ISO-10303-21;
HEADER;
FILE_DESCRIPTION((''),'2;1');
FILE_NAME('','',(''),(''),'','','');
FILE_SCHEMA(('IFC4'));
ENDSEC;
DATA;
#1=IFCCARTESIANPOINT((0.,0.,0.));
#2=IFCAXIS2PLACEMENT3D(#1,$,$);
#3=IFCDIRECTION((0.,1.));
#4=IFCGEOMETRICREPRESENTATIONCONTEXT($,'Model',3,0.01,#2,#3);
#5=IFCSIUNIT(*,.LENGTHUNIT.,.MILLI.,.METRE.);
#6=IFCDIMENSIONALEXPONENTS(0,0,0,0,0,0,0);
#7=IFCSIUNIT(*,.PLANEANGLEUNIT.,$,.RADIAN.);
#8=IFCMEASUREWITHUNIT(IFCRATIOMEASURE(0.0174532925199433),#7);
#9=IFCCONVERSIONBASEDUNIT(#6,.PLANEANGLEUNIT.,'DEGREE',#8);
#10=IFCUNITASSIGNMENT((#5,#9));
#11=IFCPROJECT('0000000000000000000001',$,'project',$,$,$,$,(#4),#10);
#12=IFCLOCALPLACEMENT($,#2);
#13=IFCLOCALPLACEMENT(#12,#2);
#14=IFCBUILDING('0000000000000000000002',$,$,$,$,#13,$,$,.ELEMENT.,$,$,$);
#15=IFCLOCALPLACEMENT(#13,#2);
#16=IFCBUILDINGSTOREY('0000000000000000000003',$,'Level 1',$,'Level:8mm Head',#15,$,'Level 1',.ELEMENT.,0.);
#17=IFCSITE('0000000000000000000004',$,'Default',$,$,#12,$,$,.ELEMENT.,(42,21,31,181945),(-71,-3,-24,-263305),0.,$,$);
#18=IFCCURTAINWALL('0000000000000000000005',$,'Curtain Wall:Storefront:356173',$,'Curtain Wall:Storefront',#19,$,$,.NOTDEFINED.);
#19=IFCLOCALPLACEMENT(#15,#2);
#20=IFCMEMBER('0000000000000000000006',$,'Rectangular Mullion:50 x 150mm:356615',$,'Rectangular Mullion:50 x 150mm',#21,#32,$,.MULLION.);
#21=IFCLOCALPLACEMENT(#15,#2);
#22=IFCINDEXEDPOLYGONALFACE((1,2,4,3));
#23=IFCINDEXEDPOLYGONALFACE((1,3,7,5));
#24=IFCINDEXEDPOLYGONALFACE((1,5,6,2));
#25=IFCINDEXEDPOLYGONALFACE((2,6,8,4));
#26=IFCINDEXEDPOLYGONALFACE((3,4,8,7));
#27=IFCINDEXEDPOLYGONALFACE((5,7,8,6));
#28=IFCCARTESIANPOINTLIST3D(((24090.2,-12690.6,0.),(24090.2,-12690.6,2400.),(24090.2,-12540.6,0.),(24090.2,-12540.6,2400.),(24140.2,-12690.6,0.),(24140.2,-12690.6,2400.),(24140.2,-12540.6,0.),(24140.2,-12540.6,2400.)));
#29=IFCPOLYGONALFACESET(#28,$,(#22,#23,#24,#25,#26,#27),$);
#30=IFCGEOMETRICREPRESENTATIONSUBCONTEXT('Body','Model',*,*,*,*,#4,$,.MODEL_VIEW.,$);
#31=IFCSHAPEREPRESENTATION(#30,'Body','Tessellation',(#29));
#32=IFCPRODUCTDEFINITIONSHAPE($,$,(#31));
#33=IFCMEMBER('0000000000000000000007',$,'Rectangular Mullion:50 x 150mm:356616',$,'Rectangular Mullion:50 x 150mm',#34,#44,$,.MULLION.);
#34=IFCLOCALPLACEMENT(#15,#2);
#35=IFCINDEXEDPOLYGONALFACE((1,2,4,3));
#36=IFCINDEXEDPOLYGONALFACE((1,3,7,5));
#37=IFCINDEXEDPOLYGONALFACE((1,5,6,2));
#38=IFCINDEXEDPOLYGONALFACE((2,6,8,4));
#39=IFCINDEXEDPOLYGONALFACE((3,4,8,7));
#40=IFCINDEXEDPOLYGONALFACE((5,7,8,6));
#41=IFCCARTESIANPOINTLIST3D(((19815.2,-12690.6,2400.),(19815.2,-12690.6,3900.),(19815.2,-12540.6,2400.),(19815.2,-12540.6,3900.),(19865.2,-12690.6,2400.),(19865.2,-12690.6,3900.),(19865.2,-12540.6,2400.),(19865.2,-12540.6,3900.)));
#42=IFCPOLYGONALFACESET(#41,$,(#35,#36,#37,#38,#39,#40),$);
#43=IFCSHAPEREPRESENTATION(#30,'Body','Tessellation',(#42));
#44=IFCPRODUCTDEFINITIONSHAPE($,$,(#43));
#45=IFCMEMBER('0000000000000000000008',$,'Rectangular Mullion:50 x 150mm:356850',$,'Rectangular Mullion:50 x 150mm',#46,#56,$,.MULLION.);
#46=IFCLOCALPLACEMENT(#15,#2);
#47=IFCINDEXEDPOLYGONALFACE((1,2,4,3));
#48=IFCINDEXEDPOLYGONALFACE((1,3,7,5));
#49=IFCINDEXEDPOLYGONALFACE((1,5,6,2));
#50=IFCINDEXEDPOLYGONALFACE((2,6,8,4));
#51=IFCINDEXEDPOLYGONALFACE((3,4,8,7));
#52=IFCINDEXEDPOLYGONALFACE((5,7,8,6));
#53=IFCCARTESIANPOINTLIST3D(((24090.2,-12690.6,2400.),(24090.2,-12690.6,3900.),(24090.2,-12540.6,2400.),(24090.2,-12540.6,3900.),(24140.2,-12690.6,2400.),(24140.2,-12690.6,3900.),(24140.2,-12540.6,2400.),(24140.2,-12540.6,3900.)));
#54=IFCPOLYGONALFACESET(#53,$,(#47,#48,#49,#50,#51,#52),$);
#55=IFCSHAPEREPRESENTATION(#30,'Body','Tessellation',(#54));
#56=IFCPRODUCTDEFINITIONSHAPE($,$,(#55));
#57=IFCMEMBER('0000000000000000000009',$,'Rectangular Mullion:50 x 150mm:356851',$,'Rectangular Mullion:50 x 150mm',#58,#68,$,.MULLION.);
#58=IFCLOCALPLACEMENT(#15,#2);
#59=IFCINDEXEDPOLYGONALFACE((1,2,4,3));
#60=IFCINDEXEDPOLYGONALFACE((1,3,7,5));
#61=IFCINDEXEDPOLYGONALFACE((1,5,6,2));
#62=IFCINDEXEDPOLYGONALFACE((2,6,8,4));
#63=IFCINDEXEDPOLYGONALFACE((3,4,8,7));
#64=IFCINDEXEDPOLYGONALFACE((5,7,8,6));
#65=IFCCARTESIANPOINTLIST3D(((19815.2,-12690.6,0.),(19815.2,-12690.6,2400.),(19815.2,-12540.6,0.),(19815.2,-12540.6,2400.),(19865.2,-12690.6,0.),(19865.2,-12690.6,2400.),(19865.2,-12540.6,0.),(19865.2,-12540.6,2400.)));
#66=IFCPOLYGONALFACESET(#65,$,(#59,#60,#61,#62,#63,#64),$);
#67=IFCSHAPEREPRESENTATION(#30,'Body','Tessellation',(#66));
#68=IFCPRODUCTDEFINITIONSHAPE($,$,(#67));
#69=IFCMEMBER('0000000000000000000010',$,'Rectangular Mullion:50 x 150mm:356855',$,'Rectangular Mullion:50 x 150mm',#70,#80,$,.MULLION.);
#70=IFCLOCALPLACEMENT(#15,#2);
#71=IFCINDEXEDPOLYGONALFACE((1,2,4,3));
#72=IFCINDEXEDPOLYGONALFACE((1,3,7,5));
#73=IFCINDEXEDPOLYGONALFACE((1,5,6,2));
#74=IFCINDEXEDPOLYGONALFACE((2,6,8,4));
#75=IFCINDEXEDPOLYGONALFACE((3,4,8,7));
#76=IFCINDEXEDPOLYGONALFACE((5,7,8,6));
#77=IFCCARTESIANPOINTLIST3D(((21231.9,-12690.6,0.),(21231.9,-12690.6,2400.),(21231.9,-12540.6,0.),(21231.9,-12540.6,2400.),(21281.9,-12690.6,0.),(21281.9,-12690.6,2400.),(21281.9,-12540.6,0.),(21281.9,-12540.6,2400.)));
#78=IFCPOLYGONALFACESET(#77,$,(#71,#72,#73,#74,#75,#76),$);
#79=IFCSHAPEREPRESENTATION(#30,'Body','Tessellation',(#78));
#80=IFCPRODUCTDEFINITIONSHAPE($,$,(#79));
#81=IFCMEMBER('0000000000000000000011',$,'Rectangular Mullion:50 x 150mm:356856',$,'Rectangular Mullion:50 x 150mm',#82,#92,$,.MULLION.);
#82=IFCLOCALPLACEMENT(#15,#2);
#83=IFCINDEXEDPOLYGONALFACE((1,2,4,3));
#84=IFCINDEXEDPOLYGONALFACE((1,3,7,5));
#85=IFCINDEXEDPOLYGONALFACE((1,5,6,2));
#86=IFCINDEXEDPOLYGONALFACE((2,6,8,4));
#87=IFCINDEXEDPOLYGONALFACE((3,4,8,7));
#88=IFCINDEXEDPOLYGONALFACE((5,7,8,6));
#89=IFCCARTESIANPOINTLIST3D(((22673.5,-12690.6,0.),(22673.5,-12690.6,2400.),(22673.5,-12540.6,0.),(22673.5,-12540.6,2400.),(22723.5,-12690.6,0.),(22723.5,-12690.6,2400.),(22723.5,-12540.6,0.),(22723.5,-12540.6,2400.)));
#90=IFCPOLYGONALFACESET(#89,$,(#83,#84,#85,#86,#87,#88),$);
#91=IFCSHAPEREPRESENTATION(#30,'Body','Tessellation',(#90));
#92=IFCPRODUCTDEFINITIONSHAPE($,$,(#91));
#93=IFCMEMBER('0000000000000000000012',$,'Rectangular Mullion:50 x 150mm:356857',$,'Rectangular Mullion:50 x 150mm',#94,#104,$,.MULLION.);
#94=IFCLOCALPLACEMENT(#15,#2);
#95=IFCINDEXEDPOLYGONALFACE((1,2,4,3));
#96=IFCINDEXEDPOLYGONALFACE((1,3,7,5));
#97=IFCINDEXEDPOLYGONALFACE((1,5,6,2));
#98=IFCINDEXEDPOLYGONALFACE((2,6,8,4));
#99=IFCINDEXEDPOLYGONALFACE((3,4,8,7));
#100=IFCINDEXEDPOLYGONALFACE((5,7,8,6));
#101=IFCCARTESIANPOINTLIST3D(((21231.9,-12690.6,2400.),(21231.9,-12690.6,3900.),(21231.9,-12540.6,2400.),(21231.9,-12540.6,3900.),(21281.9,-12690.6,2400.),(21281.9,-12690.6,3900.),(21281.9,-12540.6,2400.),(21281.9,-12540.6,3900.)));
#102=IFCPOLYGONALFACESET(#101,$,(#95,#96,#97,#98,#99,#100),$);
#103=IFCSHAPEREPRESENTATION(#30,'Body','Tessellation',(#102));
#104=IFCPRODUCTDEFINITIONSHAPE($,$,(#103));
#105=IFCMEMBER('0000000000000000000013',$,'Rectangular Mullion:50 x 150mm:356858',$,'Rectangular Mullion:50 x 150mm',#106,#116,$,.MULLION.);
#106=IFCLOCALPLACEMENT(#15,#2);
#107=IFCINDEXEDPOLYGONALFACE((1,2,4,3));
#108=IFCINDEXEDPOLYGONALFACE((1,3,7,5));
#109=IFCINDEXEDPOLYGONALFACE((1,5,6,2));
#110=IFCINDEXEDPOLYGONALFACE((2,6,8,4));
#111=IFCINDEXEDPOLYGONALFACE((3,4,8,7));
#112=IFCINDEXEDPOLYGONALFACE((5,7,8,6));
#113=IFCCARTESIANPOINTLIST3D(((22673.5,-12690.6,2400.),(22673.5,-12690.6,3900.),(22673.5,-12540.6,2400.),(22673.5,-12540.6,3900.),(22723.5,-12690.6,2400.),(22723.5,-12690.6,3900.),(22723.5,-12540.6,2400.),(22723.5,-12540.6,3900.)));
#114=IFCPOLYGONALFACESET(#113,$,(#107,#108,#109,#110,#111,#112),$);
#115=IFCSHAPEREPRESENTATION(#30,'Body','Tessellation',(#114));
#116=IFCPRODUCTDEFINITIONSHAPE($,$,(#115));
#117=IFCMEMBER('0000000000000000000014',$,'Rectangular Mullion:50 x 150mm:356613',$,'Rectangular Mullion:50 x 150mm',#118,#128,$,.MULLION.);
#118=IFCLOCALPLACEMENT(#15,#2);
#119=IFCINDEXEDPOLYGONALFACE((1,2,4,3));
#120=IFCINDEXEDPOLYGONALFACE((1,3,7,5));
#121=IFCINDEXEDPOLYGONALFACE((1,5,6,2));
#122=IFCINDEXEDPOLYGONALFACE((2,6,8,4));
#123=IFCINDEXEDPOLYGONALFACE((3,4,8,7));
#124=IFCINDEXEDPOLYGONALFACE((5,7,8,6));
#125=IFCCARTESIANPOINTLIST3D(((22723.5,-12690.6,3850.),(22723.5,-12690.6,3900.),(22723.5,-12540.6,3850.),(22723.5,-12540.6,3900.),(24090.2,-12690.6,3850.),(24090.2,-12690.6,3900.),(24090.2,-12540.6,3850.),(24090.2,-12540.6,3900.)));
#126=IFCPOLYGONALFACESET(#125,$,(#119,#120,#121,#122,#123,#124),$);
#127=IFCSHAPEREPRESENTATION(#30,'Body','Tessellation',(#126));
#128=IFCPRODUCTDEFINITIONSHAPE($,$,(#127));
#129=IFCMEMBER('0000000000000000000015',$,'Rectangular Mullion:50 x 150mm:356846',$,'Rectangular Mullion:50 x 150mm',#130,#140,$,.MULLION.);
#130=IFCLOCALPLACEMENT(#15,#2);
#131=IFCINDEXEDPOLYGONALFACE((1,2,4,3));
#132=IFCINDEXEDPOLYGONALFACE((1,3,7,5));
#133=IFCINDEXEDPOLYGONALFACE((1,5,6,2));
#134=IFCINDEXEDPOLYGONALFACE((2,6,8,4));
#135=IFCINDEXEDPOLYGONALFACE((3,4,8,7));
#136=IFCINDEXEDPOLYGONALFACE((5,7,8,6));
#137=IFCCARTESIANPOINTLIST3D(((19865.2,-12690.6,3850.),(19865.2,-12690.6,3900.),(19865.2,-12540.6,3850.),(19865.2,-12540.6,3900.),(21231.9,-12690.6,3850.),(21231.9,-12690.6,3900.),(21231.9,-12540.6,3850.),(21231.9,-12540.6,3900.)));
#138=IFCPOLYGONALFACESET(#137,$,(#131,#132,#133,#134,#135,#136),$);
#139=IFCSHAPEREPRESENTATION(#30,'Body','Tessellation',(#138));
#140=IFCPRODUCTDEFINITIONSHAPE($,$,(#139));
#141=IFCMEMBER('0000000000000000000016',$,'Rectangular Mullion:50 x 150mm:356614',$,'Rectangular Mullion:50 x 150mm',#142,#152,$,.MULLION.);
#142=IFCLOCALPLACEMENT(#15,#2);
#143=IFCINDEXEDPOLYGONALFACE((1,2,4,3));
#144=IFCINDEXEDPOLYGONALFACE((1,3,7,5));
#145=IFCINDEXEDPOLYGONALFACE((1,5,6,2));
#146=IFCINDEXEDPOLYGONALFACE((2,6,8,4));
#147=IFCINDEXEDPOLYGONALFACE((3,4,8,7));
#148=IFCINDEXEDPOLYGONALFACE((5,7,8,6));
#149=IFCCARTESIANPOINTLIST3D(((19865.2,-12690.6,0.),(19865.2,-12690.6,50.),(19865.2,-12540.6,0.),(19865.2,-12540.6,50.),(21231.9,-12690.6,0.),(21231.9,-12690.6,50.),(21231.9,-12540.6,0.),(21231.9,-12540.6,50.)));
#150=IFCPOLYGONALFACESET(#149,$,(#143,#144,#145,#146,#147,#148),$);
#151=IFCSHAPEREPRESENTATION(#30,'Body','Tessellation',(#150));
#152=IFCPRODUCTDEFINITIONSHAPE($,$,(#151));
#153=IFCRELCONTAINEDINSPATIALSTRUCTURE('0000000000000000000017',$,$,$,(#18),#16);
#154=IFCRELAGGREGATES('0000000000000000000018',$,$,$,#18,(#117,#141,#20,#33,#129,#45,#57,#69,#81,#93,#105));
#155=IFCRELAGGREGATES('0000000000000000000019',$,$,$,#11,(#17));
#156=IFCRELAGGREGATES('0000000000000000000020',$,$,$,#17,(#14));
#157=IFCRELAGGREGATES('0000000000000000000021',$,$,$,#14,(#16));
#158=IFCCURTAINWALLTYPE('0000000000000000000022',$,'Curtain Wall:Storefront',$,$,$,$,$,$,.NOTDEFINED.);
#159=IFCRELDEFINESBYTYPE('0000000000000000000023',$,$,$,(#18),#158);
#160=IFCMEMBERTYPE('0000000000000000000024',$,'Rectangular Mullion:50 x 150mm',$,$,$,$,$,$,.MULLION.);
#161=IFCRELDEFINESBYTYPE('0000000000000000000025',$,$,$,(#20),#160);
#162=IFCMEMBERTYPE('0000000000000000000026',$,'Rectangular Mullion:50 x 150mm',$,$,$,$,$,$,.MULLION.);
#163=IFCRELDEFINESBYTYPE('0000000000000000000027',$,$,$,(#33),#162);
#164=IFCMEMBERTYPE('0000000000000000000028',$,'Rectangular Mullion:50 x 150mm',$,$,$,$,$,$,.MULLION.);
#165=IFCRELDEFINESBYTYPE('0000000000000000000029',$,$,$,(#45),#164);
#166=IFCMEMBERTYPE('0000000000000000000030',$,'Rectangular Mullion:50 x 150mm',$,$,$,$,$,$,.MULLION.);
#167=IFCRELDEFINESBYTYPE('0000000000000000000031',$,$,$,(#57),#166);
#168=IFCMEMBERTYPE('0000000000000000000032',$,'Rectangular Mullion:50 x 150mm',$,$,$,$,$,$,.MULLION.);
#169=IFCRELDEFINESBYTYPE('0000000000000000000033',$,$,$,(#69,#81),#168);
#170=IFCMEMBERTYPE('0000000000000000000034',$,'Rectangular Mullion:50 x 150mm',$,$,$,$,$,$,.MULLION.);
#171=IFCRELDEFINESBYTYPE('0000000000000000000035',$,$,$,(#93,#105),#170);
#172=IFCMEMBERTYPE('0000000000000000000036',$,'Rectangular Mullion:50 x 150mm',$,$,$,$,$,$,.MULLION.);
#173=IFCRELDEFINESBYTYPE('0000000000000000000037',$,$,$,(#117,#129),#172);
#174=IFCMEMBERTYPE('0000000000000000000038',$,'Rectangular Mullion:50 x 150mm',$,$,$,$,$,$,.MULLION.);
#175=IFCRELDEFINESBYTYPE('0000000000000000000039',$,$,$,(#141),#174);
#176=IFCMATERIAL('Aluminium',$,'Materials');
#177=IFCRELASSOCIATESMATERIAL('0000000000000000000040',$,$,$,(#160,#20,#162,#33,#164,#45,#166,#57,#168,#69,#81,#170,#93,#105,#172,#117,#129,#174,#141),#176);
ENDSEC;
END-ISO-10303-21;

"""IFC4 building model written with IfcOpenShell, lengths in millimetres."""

from ifc_helpers import new_model, entity, si_unit, converted_unit, direction, frame, origin, place, context, subcontext, project, spatial, indexed_curve, outline, extrude, source, transform, mapped, material, type_object, type_shapes, element, aggregate, save


model = new_model("IFC4")

# Units and contexts
model_context = context("Model", 3, precision=0.01, world=origin(), true_north=direction((0.0, 1.0)))
body_context = subcontext(model_context, "Body", "Model", "MODEL_VIEW")
ifc_project = project(units=[si_unit("LENGTHUNIT", "METRE", prefix="MILLI"), converted_unit("PLANEANGLEUNIT", "DEGREE", entity("IfcRatioMeasure", 0.0174532925199433), si_unit("PLANEANGLEUNIT", "RADIAN"), dimensions=[0, 0, 0, 0, 0, 0, 0])], contexts=[model_context])

# Site, building, storey
site_placement = place(None, origin())
site = spatial("IfcSite", under=ifc_project, at=site_placement, Name="Default", CompositionType="ELEMENT", RefLatitude=(42, 21, 31, 181945), RefLongitude=(-71, -3, -24, -263305), RefElevation=0.0)
building_placement = place(site_placement, origin())
building = spatial("IfcBuilding", under=site, at=building_placement, CompositionType="ELEMENT")
storey_placement = place(building_placement, origin())
storey = spatial("IfcBuildingStorey", under=building, at=storey_placement, Name="Level 1", ObjectType="Level:8mm Head", LongName="Level 1", CompositionType="ELEMENT", Elevation=0.0)

# Curtain wall, members
curtain_wall_type_1 = type_object("IfcCurtainWallType", Name="Curtain Wall:Storefront", PredefinedType="NOTDEFINED")
curtain_wall_1_placement = place(storey_placement, origin())
curtain_wall_1 = element("IfcCurtainWall", 1, at=curtain_wall_1_placement, inside=storey, type_object=curtain_wall_type_1, Name="Curtain Wall:Storefront:356173", ObjectType="Curtain Wall:Storefront", PredefinedType="NOTDEFINED")
ifc_material_1 = material(Name="Aluminium", Category="Materials")
member_type_1 = type_object("IfcMemberType", Name="Rectangular Mullion:50 x 150mm", PredefinedType="MULLION", material=ifc_material_1)
shared_shape_1 = source(origin(), body_context, "Body", "SweptSolid", [
    extrude(outline(indexed_curve([(-75.0, -25.0), (75.0, -25.0), (75.0, 25.0), (-75.0, 25.0), (-75.0, -25.0)], self_intersect=False)), frame((-25.0, 0.0, -2400.0), z_axis=(0.0, 0.0, 1.0), x_axis=(0.0, -1.0, 0.0)), (0.0, 0.0, 1.0), 2400.0),
])
type_shapes(member_type_1, [shared_shape_1])
member_1_placement = place(storey_placement, frame((24140.2, -12615.6, 0.0), z_axis=(0.0, 0.0, -1.0), x_axis=(1.0, 0.0, 0.0)))
member_1 = element("IfcMember", 2, at=member_1_placement, type_object=member_type_1, material=ifc_material_1, Name="Rectangular Mullion:50 x 150mm:356615", ObjectType="Rectangular Mullion:50 x 150mm", PredefinedType="MULLION", context=body_context, shape_type="MappedRepresentation", body=[
    mapped(shared_shape_1, transform((0.0, 0.0, 0.0), scale=1.0)),
])
member_type_2 = type_object("IfcMemberType", Name="Rectangular Mullion:50 x 150mm", PredefinedType="MULLION", material=ifc_material_1)
shared_shape_2 = source(origin(), body_context, "Body", "SweptSolid", [
    extrude(outline(indexed_curve([(-75.0, -25.0), (75.0, -25.0), (75.0, 25.0), (-75.0, 25.0), (-75.0, -25.0)], self_intersect=False)), frame((-25.0, 0.0, -1500.0), z_axis=(0.0, 0.0, 1.0), x_axis=(0.0, -1.0, 0.0)), (0.0, 0.0, 1.0), 1500.0),
])
type_shapes(member_type_2, [shared_shape_2])
member_2_placement = place(storey_placement, frame((19815.2, -12615.6, 3900.0), z_axis=(0.0, 0.0, 1.0), x_axis=(-1.0, 0.0, 0.0)))
member_2 = element("IfcMember", 3, at=member_2_placement, type_object=member_type_2, material=ifc_material_1, Name="Rectangular Mullion:50 x 150mm:356616", ObjectType="Rectangular Mullion:50 x 150mm", PredefinedType="MULLION", context=body_context, shape_type="MappedRepresentation", body=[
    mapped(shared_shape_2, transform((0.0, 0.0, 0.0), scale=1.0)),
])
member_type_3 = type_object("IfcMemberType", Name="Rectangular Mullion:50 x 150mm", PredefinedType="MULLION", material=ifc_material_1)
shared_shape_3 = source(origin(), body_context, "Body", "SweptSolid", [
    extrude(outline(indexed_curve([(-75.0, -25.0), (75.0, -25.0), (75.0, 25.0), (-75.0, 25.0), (-75.0, -25.0)], self_intersect=False)), frame((-25.0, 0.0, -1500.0), z_axis=(0.0, 0.0, 1.0), x_axis=(0.0, -1.0, 0.0)), (0.0, 0.0, 1.0), 1500.0),
])
type_shapes(member_type_3, [shared_shape_3])
member_3_placement = place(storey_placement, frame((24140.2, -12615.6, 2400.0), z_axis=(0.0, 0.0, -1.0), x_axis=(1.0, 0.0, 0.0)))
member_3 = element("IfcMember", 4, at=member_3_placement, type_object=member_type_3, material=ifc_material_1, Name="Rectangular Mullion:50 x 150mm:356850", ObjectType="Rectangular Mullion:50 x 150mm", PredefinedType="MULLION", context=body_context, shape_type="MappedRepresentation", body=[
    mapped(shared_shape_3, transform((0.0, 0.0, 0.0), scale=1.0)),
])
member_type_4 = type_object("IfcMemberType", Name="Rectangular Mullion:50 x 150mm", PredefinedType="MULLION", material=ifc_material_1)
shared_shape_4 = source(origin(), body_context, "Body", "SweptSolid", [
    extrude(outline(indexed_curve([(-75.0, -25.0), (75.0, -25.0), (75.0, 25.0), (-75.0, 25.0), (-75.0, -25.0)], self_intersect=False)), frame((-25.0, 0.0, -2400.0), z_axis=(0.0, 0.0, 1.0), x_axis=(0.0, -1.0, 0.0)), (0.0, 0.0, 1.0), 2400.0),
])
type_shapes(member_type_4, [shared_shape_4])
member_4_placement = place(storey_placement, frame((19815.2, -12615.6, 2400.0), z_axis=(0.0, 0.0, 1.0), x_axis=(-1.0, 0.0, 0.0)))
member_4 = element("IfcMember", 5, at=member_4_placement, type_object=member_type_4, material=ifc_material_1, Name="Rectangular Mullion:50 x 150mm:356851", ObjectType="Rectangular Mullion:50 x 150mm", PredefinedType="MULLION", context=body_context, shape_type="MappedRepresentation", body=[
    mapped(shared_shape_4, transform((0.0, 0.0, 0.0), scale=1.0)),
])
member_type_5 = type_object("IfcMemberType", Name="Rectangular Mullion:50 x 150mm", PredefinedType="MULLION", material=ifc_material_1)
shared_shape_5 = source(origin(), body_context, "Body", "SweptSolid", [
    extrude(outline(indexed_curve([(-75.0, -25.0), (75.0, -25.0), (75.0, 25.0), (-75.0, 25.0), (-75.0, -25.0)], self_intersect=False)), frame((0.0, 0.0, -2400.0), z_axis=(0.0, 0.0, 1.0), x_axis=(0.0, -1.0, 0.0)), (0.0, 0.0, 1.0), 2400.0),
])
type_shapes(member_type_5, [shared_shape_5])
member_5_placement = place(storey_placement, frame((21256.9, -12615.6, 0.0), z_axis=(0.0, 0.0, -1.0), x_axis=(1.0, 0.0, 0.0)))
member_5 = element("IfcMember", 6, at=member_5_placement, type_object=member_type_5, material=ifc_material_1, Name="Rectangular Mullion:50 x 150mm:356855", ObjectType="Rectangular Mullion:50 x 150mm", PredefinedType="MULLION", context=body_context, shape_type="MappedRepresentation", body=[
    mapped(shared_shape_5, transform((0.0, 0.0, 0.0), scale=1.0)),
])
member_6_placement = place(storey_placement, frame((22698.5, -12615.6, 0.0), z_axis=(0.0, 0.0, -1.0), x_axis=(1.0, 0.0, 0.0)))
member_6 = element("IfcMember", 7, at=member_6_placement, type_object=member_type_5, material=ifc_material_1, Name="Rectangular Mullion:50 x 150mm:356856", ObjectType="Rectangular Mullion:50 x 150mm", PredefinedType="MULLION", context=body_context, shape_type="MappedRepresentation", body=[
    mapped(shared_shape_5, transform((0.0, 0.0, 0.0), scale=1.0)),
])
member_type_6 = type_object("IfcMemberType", Name="Rectangular Mullion:50 x 150mm", PredefinedType="MULLION", material=ifc_material_1)
shared_shape_6 = source(origin(), body_context, "Body", "SweptSolid", [
    extrude(outline(indexed_curve([(-75.0, -25.0), (75.0, -25.0), (75.0, 25.0), (-75.0, 25.0), (-75.0, -25.0)], self_intersect=False)), frame((0.0, 0.0, -1500.0), z_axis=(0.0, 0.0, 1.0), x_axis=(0.0, -1.0, 0.0)), (0.0, 0.0, 1.0), 1500.0),
])
type_shapes(member_type_6, [shared_shape_6])
member_7_placement = place(storey_placement, frame((21256.9, -12615.6, 2400.0), z_axis=(0.0, 0.0, -1.0), x_axis=(1.0, 0.0, 0.0)))
member_7 = element("IfcMember", 8, at=member_7_placement, type_object=member_type_6, material=ifc_material_1, Name="Rectangular Mullion:50 x 150mm:356857", ObjectType="Rectangular Mullion:50 x 150mm", PredefinedType="MULLION", context=body_context, shape_type="MappedRepresentation", body=[
    mapped(shared_shape_6, transform((0.0, 0.0, 0.0), scale=1.0)),
])
member_8_placement = place(storey_placement, frame((22698.5, -12615.6, 2400.0), z_axis=(0.0, 0.0, -1.0), x_axis=(1.0, 0.0, 0.0)))
member_8 = element("IfcMember", 9, at=member_8_placement, type_object=member_type_6, material=ifc_material_1, Name="Rectangular Mullion:50 x 150mm:356858", ObjectType="Rectangular Mullion:50 x 150mm", PredefinedType="MULLION", context=body_context, shape_type="MappedRepresentation", body=[
    mapped(shared_shape_6, transform((0.0, 0.0, 0.0), scale=1.0)),
])
member_type_7 = type_object("IfcMemberType", Name="Rectangular Mullion:50 x 150mm", PredefinedType="MULLION", material=ifc_material_1)
shared_shape_7 = source(origin(), body_context, "Body", "SweptSolid", [
    extrude(outline(indexed_curve([(-75.0, -25.0), (75.0, -25.0), (75.0, 25.0), (-75.0, 25.0), (-75.0, -25.0)], self_intersect=False)), frame((-25.0, 0.0, -1366.7), z_axis=(0.0, 0.0, 1.0), x_axis=(0.0, -1.0, 0.0)), (0.0, 0.0, 1.0), 1366.7),
])
type_shapes(member_type_7, [shared_shape_7])
member_9_placement = place(storey_placement, frame((24090.2, -12615.6, 3900.0), z_axis=(1.0, 0.0, 0.0), x_axis=(0.0, 0.0, 1.0)))
member_9 = element("IfcMember", 10, at=member_9_placement, type_object=member_type_7, material=ifc_material_1, Name="Rectangular Mullion:50 x 150mm:356613", ObjectType="Rectangular Mullion:50 x 150mm", PredefinedType="MULLION", context=body_context, shape_type="MappedRepresentation", body=[
    mapped(shared_shape_7, transform((0.0, 0.0, 0.0), scale=1.0)),
])
member_10_placement = place(storey_placement, frame((21231.9, -12615.6, 3900.0), z_axis=(1.0, 0.0, 0.0), x_axis=(0.0, 0.0, 1.0)))
member_10 = element("IfcMember", 11, at=member_10_placement, type_object=member_type_7, material=ifc_material_1, Name="Rectangular Mullion:50 x 150mm:356846", ObjectType="Rectangular Mullion:50 x 150mm", PredefinedType="MULLION", context=body_context, shape_type="MappedRepresentation", body=[
    mapped(shared_shape_7, transform((0.0, 0.0, 0.0), scale=1.0)),
])
member_type_8 = type_object("IfcMemberType", Name="Rectangular Mullion:50 x 150mm", PredefinedType="MULLION", material=ifc_material_1)
shared_shape_8 = source(origin(), body_context, "Body", "SweptSolid", [
    extrude(outline(indexed_curve([(-75.0, -25.0), (75.0, -25.0), (75.0, 25.0), (-75.0, 25.0), (-75.0, -25.0)], self_intersect=False)), frame((-25.0, 0.0, -1366.7), z_axis=(0.0, 0.0, 1.0), x_axis=(0.0, -1.0, 0.0)), (0.0, 0.0, 1.0), 1366.7),
])
type_shapes(member_type_8, [shared_shape_8])
member_11_placement = place(storey_placement, frame((19865.2, -12615.6, 0.0), z_axis=(-1.0, 0.0, 0.0), x_axis=(0.0, 0.0, -1.0)))
member_11 = element("IfcMember", 12, at=member_11_placement, type_object=member_type_8, material=ifc_material_1, Name="Rectangular Mullion:50 x 150mm:356614", ObjectType="Rectangular Mullion:50 x 150mm", PredefinedType="MULLION", context=body_context, shape_type="MappedRepresentation", body=[
    mapped(shared_shape_8, transform((0.0, 0.0, 0.0), scale=1.0)),
])

aggregate(curtain_wall_1, [member_9, member_11, member_1, member_2, member_10, member_3, member_4, member_5, member_6, member_7, member_8])

save(model, "model.ifc")
